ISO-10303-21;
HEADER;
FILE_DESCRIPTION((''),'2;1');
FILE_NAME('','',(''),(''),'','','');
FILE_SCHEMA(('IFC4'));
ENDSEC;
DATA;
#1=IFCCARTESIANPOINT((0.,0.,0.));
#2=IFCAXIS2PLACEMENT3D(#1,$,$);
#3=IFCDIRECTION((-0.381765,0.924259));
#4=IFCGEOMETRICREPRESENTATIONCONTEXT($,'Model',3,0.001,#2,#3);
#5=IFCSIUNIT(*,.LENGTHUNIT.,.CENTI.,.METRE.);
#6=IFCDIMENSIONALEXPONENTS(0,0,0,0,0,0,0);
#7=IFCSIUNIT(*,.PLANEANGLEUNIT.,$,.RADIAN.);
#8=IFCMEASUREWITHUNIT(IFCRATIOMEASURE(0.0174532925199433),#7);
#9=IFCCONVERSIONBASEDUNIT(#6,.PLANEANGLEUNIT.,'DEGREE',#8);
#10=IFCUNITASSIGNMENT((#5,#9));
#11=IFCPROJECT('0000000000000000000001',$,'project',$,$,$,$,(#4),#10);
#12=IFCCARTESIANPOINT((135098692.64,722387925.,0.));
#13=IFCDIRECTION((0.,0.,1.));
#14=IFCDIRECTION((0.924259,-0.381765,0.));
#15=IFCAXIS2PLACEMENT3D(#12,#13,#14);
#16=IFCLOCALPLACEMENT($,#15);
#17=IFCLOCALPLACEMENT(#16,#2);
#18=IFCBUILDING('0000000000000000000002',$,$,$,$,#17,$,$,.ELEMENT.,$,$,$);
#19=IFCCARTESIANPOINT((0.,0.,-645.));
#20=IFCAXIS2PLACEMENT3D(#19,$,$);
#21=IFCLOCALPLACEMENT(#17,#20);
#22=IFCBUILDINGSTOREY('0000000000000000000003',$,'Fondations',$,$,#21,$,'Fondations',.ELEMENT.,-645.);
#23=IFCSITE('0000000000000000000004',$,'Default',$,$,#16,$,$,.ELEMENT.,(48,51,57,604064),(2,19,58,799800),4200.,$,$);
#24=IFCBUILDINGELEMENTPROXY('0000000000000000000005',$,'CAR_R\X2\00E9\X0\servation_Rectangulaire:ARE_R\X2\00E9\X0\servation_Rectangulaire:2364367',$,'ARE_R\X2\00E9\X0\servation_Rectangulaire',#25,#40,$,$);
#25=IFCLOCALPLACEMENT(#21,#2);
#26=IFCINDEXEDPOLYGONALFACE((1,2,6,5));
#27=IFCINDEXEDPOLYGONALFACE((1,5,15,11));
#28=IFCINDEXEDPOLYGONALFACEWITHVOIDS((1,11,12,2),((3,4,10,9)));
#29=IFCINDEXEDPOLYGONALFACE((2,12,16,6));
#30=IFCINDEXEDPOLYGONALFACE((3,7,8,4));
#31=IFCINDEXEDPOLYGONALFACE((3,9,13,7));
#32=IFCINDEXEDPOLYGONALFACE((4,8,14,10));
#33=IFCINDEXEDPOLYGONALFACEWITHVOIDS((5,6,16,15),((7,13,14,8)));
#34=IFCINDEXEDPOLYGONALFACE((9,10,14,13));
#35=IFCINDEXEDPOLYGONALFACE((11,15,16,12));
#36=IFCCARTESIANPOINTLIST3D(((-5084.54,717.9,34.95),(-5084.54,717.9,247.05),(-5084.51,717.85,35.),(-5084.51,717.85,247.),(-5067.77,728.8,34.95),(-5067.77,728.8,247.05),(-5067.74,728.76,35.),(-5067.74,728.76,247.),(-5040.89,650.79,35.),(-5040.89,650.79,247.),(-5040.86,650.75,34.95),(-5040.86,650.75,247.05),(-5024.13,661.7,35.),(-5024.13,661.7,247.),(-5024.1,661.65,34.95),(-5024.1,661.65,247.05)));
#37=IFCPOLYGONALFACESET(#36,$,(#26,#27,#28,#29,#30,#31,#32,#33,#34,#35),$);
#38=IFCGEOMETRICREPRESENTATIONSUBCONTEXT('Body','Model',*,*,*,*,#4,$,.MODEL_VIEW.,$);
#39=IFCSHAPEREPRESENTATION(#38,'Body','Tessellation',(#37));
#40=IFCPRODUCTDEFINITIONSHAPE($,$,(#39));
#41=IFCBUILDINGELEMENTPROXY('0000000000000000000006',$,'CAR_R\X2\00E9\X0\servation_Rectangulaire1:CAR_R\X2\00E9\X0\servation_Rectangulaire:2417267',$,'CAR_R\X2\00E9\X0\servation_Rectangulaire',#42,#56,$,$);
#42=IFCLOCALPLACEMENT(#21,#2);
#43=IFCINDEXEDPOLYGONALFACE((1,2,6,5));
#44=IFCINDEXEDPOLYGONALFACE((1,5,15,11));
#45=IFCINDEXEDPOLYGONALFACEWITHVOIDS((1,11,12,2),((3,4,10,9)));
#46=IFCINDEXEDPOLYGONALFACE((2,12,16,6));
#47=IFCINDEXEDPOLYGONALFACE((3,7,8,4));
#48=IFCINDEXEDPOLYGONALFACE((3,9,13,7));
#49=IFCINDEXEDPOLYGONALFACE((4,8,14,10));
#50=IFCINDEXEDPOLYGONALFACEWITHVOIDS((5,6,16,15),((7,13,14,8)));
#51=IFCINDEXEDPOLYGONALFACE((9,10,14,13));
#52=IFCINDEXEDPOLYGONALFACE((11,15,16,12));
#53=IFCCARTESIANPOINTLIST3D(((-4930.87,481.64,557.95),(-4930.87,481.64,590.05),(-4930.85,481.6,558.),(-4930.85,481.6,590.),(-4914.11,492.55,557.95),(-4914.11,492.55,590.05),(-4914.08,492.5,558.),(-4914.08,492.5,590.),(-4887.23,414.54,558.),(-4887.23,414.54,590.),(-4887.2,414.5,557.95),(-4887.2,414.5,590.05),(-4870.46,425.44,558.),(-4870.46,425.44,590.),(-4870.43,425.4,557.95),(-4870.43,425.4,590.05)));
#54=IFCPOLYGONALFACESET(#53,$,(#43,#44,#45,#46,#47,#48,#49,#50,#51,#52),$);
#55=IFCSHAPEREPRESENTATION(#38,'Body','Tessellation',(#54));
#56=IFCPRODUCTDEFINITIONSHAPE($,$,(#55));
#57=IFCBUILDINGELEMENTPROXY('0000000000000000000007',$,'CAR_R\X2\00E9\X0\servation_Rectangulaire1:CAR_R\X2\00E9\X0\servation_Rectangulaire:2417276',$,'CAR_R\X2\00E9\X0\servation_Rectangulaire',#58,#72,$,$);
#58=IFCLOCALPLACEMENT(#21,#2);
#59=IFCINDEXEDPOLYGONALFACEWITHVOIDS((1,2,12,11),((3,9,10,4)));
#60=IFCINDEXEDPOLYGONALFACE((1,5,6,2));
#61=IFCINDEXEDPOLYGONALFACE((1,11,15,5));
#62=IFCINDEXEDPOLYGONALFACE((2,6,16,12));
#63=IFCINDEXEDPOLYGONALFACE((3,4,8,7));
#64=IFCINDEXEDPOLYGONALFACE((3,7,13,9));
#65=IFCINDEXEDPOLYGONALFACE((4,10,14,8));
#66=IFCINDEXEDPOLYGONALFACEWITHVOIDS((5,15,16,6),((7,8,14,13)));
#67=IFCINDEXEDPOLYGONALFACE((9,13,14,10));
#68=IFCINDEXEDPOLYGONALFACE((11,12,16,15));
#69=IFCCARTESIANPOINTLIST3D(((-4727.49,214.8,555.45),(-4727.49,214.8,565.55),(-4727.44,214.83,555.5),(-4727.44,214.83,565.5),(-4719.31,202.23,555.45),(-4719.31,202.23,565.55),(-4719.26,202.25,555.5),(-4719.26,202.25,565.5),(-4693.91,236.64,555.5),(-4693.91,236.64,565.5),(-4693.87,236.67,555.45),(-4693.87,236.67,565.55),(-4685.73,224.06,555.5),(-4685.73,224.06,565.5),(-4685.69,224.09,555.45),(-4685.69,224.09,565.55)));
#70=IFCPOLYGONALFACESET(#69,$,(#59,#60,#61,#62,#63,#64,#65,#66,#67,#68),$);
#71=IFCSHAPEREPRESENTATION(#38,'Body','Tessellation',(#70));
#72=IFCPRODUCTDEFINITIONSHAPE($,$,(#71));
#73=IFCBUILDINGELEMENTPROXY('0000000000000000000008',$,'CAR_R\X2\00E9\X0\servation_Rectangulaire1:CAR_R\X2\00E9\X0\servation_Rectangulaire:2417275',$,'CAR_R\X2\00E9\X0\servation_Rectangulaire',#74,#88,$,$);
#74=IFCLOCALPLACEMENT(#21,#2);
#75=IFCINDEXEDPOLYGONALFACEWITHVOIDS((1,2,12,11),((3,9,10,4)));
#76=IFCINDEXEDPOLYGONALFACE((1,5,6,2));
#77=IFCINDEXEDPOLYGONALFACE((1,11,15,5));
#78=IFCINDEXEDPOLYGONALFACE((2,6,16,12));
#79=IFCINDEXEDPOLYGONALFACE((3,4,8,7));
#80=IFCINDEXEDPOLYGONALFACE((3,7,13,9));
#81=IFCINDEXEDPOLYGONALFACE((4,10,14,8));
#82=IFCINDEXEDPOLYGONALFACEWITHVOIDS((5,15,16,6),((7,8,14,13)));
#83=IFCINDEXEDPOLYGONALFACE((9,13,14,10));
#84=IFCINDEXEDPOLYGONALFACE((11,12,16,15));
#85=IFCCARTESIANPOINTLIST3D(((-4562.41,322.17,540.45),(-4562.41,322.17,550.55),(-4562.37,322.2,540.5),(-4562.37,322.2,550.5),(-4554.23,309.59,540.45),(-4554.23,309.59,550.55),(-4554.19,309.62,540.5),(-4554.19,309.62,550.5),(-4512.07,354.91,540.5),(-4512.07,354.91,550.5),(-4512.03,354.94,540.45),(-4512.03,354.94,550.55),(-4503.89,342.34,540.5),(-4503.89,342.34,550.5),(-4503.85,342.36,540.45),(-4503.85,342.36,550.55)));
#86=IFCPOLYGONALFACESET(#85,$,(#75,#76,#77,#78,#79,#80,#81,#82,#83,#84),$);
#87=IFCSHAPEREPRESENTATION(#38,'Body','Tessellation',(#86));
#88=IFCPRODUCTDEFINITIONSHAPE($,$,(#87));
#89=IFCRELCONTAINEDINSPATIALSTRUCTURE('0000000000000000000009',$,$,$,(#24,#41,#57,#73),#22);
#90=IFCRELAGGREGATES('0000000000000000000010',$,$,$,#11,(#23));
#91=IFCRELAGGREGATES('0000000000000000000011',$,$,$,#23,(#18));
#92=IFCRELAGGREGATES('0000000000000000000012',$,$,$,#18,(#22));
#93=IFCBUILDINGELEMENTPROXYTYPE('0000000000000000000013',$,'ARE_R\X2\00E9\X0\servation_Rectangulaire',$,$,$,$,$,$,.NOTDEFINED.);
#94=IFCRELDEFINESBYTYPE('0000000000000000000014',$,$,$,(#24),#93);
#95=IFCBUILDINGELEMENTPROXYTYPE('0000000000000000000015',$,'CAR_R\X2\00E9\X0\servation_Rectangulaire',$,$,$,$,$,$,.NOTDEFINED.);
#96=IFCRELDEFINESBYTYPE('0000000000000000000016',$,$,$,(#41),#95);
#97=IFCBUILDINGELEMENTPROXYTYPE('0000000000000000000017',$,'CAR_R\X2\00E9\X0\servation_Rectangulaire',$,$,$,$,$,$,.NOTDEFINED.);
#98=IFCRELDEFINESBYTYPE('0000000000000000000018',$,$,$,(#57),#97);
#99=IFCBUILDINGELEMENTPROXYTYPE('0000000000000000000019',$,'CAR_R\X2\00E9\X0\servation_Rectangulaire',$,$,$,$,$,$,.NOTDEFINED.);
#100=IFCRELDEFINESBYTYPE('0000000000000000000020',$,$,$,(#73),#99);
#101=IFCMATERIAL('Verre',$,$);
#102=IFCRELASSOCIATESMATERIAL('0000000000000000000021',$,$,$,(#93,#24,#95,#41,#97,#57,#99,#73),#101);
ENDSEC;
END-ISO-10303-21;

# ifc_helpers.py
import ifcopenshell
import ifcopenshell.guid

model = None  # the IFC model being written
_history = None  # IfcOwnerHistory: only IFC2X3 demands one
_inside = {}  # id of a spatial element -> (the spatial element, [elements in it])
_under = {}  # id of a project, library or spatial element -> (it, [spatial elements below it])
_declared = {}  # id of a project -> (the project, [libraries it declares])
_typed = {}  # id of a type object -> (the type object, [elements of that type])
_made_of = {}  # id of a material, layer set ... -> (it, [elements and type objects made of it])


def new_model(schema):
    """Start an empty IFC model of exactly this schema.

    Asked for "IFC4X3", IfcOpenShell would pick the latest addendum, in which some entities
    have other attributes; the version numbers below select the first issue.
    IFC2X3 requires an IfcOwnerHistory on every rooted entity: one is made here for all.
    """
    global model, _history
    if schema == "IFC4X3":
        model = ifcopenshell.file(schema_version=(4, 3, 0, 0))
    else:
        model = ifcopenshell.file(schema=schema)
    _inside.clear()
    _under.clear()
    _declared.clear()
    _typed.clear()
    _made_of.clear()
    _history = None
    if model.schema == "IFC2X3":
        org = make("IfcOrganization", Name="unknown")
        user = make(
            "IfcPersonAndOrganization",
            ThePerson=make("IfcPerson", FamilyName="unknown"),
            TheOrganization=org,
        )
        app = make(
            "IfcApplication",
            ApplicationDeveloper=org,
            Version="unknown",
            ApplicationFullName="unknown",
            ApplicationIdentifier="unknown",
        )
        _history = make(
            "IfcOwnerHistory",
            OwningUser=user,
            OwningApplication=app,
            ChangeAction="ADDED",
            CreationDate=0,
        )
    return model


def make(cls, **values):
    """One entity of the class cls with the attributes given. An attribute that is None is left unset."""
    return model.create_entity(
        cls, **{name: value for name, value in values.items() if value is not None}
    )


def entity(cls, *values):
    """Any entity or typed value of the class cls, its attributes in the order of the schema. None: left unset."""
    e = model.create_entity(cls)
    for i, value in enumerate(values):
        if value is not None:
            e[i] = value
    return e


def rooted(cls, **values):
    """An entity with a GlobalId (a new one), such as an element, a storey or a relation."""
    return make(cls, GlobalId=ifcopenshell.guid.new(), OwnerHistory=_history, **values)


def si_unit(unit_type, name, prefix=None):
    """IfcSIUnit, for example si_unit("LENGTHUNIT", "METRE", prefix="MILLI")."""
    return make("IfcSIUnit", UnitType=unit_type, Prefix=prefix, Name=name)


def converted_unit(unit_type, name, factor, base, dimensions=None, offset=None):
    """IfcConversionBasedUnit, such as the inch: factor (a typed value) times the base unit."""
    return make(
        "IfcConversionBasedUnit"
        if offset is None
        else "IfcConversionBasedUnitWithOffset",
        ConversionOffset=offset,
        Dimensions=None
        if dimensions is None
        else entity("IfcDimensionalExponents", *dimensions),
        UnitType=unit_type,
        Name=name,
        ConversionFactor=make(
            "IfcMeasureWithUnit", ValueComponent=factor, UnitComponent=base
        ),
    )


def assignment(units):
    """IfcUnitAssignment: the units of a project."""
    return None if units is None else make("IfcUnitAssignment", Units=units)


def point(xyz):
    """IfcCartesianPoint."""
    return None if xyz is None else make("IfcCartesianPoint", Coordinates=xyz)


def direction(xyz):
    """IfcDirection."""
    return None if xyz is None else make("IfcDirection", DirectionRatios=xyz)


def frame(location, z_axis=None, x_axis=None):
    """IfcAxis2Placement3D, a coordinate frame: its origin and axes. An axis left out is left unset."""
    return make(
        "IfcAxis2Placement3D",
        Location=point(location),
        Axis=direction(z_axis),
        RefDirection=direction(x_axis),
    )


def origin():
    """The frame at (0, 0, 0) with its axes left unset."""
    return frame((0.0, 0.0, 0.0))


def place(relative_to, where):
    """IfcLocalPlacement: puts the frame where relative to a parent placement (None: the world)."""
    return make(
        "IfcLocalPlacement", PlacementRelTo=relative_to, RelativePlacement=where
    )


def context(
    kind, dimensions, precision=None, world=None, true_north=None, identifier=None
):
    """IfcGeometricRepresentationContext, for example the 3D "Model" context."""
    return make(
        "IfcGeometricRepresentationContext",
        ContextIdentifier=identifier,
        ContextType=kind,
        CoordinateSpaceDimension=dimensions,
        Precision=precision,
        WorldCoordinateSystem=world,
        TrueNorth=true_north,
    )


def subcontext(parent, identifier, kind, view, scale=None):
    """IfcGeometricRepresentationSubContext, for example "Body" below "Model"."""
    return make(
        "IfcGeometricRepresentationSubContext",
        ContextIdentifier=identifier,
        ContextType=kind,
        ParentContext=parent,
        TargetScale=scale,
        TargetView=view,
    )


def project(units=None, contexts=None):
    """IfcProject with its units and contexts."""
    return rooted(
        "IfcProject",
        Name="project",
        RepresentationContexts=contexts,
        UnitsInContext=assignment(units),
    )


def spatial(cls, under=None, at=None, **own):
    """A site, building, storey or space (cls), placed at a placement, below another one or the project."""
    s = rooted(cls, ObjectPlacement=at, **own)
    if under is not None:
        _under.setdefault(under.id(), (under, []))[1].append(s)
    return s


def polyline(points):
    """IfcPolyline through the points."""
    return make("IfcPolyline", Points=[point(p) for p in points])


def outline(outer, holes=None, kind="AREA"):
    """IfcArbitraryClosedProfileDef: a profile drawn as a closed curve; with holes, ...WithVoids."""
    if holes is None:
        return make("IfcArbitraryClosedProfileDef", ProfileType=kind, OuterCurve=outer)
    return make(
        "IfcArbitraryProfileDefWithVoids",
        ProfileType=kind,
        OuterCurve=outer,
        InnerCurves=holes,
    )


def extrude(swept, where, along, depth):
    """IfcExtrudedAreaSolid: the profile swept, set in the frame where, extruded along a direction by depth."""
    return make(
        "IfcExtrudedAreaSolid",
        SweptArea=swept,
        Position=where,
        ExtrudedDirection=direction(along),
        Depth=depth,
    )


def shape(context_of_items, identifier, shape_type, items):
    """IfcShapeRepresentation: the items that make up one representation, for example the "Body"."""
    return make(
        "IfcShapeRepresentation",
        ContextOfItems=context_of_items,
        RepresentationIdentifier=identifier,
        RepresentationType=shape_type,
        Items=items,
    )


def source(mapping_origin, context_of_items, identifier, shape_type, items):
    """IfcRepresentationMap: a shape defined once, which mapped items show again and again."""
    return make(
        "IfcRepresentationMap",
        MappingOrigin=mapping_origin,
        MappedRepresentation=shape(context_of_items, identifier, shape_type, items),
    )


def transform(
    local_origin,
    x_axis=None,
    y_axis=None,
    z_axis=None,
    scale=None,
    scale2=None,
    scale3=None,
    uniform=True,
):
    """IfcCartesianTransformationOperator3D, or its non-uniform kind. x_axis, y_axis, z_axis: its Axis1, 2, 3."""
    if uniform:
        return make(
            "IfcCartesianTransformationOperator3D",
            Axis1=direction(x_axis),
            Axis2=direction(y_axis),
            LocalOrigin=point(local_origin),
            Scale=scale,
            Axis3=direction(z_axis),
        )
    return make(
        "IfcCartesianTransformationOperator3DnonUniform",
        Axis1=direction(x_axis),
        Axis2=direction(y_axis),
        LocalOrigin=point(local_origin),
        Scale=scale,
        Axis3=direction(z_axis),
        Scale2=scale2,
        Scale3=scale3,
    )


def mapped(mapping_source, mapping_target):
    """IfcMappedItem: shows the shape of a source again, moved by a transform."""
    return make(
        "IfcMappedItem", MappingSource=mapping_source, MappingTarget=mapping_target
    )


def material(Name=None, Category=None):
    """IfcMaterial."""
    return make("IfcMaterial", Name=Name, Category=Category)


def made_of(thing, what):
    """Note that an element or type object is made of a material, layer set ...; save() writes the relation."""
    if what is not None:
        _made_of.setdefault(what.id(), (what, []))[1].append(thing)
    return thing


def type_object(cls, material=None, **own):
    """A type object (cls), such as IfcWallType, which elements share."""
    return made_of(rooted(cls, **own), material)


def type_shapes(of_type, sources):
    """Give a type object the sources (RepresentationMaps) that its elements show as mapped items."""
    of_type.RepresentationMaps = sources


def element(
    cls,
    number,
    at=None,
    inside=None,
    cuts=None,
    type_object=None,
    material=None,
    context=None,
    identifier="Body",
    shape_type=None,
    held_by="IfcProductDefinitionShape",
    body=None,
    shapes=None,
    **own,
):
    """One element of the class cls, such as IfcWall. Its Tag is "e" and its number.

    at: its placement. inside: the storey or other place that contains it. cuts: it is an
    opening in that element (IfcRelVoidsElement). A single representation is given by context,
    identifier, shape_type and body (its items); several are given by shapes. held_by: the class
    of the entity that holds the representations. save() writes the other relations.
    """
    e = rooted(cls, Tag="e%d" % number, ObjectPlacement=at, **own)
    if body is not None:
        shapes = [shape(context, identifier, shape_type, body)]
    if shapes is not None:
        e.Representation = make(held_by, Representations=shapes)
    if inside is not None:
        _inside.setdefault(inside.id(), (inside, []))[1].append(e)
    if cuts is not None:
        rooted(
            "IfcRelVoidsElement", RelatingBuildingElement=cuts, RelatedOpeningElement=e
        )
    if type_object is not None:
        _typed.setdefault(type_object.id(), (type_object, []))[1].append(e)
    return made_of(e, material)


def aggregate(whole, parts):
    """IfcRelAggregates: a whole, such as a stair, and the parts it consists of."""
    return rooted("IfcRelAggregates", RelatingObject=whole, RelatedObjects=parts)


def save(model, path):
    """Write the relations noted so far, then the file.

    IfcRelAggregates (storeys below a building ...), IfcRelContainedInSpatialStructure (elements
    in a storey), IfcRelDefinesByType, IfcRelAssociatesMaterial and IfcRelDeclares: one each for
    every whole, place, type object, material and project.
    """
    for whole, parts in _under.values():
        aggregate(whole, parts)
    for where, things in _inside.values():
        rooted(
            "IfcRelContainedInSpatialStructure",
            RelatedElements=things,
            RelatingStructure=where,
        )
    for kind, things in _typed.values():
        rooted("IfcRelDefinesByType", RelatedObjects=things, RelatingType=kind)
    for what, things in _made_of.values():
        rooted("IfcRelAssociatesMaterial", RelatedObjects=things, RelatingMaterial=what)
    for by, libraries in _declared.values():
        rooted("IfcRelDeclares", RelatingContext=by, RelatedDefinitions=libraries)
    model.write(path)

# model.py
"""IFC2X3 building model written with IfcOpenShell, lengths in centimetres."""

from ifc_helpers import new_model, entity, si_unit, converted_unit, direction, frame, origin, place, context, subcontext, project, spatial, polyline, outline, extrude, source, transform, mapped, material, type_object, type_shapes, element, save


model = new_model("IFC2X3")

# Units and contexts
model_context = context("Model", 3, precision=0.001, world=origin(), true_north=direction((-0.381765, 0.924259)))
body_context = subcontext(model_context, "Body", "Model", "MODEL_VIEW")
ifc_project = project(units=[si_unit("LENGTHUNIT", "METRE", prefix="CENTI"), converted_unit("PLANEANGLEUNIT", "DEGREE", entity("IfcRatioMeasure", 0.0174532925199433), si_unit("PLANEANGLEUNIT", "RADIAN"), dimensions=[0, 0, 0, 0, 0, 0, 0])], contexts=[model_context])

# Site, building, storey
site_placement = place(None, frame((135098692.64, 722387925.0, 0.0), z_axis=(0.0, 0.0, 1.0), x_axis=(0.924259, -0.381765, 0.0)))
site = spatial("IfcSite", under=ifc_project, at=site_placement, Name="Default", CompositionType="ELEMENT", RefLatitude=(48, 51, 57, 604064), RefLongitude=(2, 19, 58, 799800), RefElevation=4200.0)
building_placement = place(site_placement, origin())
building = spatial("IfcBuilding", under=site, at=building_placement, CompositionType="ELEMENT")
storey_placement = place(building_placement, frame((0.0, 0.0, -645.0)))
storey = spatial("IfcBuildingStorey", under=building, at=storey_placement, Name="Fondations", LongName="Fondations", CompositionType="ELEMENT", Elevation=-645.0)

# Building element proxies
ifc_material_1 = material(Name="Verre")
building_element_proxy_type_1 = type_object("IfcBuildingElementProxyType", Name="ARE_Réservation_Rectangulaire", PredefinedType="NOTDEFINED", material=ifc_material_1)
shared_shape_1 = source(origin(), body_context, "Body", "SweptSolid", [
    extrude(outline(polyline([(-40.05, -106.05), (40.05, -106.05), (40.05, 106.05), (-40.05, 106.05), (-40.05, -106.05)]), holes=[polyline([(40.0, -106.0), (-40.0, -106.0), (-40.0, 106.0), (40.0, 106.0), (40.0, -106.0)])]), frame((0.0, 0.0, -20.0), z_axis=(0.0, 0.0, 1.0), x_axis=(-1.0, 0.0, 0.0)), (0.0, 0.0, 1.0), 20.0),
])
type_shapes(building_element_proxy_type_1, [shared_shape_1])
proxy_1_placement = place(storey_placement, frame((-5062.7, 684.32, 141.0), z_axis=(-0.838282, -0.545236, 0.0), x_axis=(0.545236, -0.838282, 0.0)))
element("IfcBuildingElementProxy", 1, at=proxy_1_placement, inside=storey, type_object=building_element_proxy_type_1, material=ifc_material_1, Name="CAR_Réservation_Rectangulaire:ARE_Réservation_Rectangulaire:2364367", ObjectType="ARE_Réservation_Rectangulaire", context=body_context, shape_type="MappedRepresentation", body=[
    mapped(shared_shape_1, transform((0.0, 0.0, 0.0), scale=1.0)),
])
building_element_proxy_type_2 = type_object("IfcBuildingElementProxyType", Name="CAR_Réservation_Rectangulaire", PredefinedType="NOTDEFINED", material=ifc_material_1)
shared_shape_2 = source(origin(), body_context, "Body", "SweptSolid", [
    extrude(outline(polyline([(-40.05, -16.05), (40.05, -16.05), (40.05, 16.05), (-40.05, 16.05), (-40.05, -16.05)]), holes=[polyline([(40.0, -16.0), (-40.0, -16.0), (-40.0, 16.0), (40.0, 16.0), (40.0, -16.0)])]), frame((0.0, 0.0, -20.0), z_axis=(0.0, 0.0, 1.0), x_axis=(-1.0, 0.0, 0.0)), (0.0, 0.0, 1.0), 20.0),
])
type_shapes(building_element_proxy_type_2, [shared_shape_2])
proxy_2_placement = place(storey_placement, frame((-4892.27, 458.97, 574.0), z_axis=(0.838282, 0.545236, 0.0), x_axis=(-0.545236, 0.838282, 0.0)))
element("IfcBuildingElementProxy", 2, at=proxy_2_placement, inside=storey, type_object=building_element_proxy_type_2, material=ifc_material_1, Name="CAR_Réservation_Rectangulaire1:CAR_Réservation_Rectangulaire:2417267", ObjectType="CAR_Réservation_Rectangulaire", context=body_context, shape_type="MappedRepresentation", body=[
    mapped(shared_shape_2, transform((0.0, 0.0, 0.0), scale=1.0)),
])
building_element_proxy_type_3 = type_object("IfcBuildingElementProxyType", Name="CAR_Réservation_Rectangulaire", PredefinedType="NOTDEFINED", material=ifc_material_1)
shared_shape_3 = source(origin(), body_context, "Body", "SweptSolid", [
    extrude(outline(polyline([(-20.05, -5.05), (20.05, -5.05), (20.05, 5.05), (-20.05, 5.05), (-20.05, -5.05)]), holes=[polyline([(20.0, -5.0), (-20.0, -5.0), (-20.0, 5.0), (20.0, 5.0), (20.0, -5.0)])]), frame((0.0, 0.0, -15.0), z_axis=(0.0, 0.0, 1.0), x_axis=(-1.0, 0.0, 0.0)), (0.0, 0.0, 1.0), 15.0),
])
type_shapes(building_element_proxy_type_3, [shared_shape_3])
proxy_3_placement = place(storey_placement, frame((-4702.5, 213.16, 560.5), z_axis=(0.545236, -0.838282, 0.0), x_axis=(0.838282, 0.545236, 0.0)))
element("IfcBuildingElementProxy", 3, at=proxy_3_placement, inside=storey, type_object=building_element_proxy_type_3, material=ifc_material_1, Name="CAR_Réservation_Rectangulaire1:CAR_Réservation_Rectangulaire:2417276", ObjectType="CAR_Réservation_Rectangulaire", context=body_context, shape_type="MappedRepresentation", body=[
    mapped(shared_shape_3, transform((0.0, 0.0, 0.0), scale=1.0)),
])
building_element_proxy_type_4 = type_object("IfcBuildingElementProxyType", Name="CAR_Réservation_Rectangulaire", PredefinedType="NOTDEFINED", material=ifc_material_1)
shared_shape_4 = source(origin(), body_context, "Body", "SweptSolid", [
    extrude(outline(polyline([(-30.05, -5.05), (30.05, -5.05), (30.05, 5.05), (-30.05, 5.05), (-30.05, -5.05)]), holes=[polyline([(30.0, -5.0), (-30.0, -5.0), (-30.0, 5.0), (30.0, 5.0), (30.0, -5.0)])]), frame((0.0, 0.0, -15.0), z_axis=(0.0, 0.0, 1.0), x_axis=(-1.0, 0.0, 0.0)), (0.0, 0.0, 1.0), 15.0),
])
type_shapes(building_element_proxy_type_4, [shared_shape_4])
proxy_4_placement = place(storey_placement, frame((-4529.04, 325.98, 545.5), z_axis=(0.545236, -0.838282, 0.0), x_axis=(0.838282, 0.545236, 0.0)))
element("IfcBuildingElementProxy", 4, at=proxy_4_placement, inside=storey, type_object=building_element_proxy_type_4, material=ifc_material_1, Name="CAR_Réservation_Rectangulaire1:CAR_Réservation_Rectangulaire:2417275", ObjectType="CAR_Réservation_Rectangulaire", context=body_context, shape_type="MappedRepresentation", body=[
    mapped(shared_shape_4, transform((0.0, 0.0, 0.0), scale=1.0)),
])

save(model, "model.ifc")
